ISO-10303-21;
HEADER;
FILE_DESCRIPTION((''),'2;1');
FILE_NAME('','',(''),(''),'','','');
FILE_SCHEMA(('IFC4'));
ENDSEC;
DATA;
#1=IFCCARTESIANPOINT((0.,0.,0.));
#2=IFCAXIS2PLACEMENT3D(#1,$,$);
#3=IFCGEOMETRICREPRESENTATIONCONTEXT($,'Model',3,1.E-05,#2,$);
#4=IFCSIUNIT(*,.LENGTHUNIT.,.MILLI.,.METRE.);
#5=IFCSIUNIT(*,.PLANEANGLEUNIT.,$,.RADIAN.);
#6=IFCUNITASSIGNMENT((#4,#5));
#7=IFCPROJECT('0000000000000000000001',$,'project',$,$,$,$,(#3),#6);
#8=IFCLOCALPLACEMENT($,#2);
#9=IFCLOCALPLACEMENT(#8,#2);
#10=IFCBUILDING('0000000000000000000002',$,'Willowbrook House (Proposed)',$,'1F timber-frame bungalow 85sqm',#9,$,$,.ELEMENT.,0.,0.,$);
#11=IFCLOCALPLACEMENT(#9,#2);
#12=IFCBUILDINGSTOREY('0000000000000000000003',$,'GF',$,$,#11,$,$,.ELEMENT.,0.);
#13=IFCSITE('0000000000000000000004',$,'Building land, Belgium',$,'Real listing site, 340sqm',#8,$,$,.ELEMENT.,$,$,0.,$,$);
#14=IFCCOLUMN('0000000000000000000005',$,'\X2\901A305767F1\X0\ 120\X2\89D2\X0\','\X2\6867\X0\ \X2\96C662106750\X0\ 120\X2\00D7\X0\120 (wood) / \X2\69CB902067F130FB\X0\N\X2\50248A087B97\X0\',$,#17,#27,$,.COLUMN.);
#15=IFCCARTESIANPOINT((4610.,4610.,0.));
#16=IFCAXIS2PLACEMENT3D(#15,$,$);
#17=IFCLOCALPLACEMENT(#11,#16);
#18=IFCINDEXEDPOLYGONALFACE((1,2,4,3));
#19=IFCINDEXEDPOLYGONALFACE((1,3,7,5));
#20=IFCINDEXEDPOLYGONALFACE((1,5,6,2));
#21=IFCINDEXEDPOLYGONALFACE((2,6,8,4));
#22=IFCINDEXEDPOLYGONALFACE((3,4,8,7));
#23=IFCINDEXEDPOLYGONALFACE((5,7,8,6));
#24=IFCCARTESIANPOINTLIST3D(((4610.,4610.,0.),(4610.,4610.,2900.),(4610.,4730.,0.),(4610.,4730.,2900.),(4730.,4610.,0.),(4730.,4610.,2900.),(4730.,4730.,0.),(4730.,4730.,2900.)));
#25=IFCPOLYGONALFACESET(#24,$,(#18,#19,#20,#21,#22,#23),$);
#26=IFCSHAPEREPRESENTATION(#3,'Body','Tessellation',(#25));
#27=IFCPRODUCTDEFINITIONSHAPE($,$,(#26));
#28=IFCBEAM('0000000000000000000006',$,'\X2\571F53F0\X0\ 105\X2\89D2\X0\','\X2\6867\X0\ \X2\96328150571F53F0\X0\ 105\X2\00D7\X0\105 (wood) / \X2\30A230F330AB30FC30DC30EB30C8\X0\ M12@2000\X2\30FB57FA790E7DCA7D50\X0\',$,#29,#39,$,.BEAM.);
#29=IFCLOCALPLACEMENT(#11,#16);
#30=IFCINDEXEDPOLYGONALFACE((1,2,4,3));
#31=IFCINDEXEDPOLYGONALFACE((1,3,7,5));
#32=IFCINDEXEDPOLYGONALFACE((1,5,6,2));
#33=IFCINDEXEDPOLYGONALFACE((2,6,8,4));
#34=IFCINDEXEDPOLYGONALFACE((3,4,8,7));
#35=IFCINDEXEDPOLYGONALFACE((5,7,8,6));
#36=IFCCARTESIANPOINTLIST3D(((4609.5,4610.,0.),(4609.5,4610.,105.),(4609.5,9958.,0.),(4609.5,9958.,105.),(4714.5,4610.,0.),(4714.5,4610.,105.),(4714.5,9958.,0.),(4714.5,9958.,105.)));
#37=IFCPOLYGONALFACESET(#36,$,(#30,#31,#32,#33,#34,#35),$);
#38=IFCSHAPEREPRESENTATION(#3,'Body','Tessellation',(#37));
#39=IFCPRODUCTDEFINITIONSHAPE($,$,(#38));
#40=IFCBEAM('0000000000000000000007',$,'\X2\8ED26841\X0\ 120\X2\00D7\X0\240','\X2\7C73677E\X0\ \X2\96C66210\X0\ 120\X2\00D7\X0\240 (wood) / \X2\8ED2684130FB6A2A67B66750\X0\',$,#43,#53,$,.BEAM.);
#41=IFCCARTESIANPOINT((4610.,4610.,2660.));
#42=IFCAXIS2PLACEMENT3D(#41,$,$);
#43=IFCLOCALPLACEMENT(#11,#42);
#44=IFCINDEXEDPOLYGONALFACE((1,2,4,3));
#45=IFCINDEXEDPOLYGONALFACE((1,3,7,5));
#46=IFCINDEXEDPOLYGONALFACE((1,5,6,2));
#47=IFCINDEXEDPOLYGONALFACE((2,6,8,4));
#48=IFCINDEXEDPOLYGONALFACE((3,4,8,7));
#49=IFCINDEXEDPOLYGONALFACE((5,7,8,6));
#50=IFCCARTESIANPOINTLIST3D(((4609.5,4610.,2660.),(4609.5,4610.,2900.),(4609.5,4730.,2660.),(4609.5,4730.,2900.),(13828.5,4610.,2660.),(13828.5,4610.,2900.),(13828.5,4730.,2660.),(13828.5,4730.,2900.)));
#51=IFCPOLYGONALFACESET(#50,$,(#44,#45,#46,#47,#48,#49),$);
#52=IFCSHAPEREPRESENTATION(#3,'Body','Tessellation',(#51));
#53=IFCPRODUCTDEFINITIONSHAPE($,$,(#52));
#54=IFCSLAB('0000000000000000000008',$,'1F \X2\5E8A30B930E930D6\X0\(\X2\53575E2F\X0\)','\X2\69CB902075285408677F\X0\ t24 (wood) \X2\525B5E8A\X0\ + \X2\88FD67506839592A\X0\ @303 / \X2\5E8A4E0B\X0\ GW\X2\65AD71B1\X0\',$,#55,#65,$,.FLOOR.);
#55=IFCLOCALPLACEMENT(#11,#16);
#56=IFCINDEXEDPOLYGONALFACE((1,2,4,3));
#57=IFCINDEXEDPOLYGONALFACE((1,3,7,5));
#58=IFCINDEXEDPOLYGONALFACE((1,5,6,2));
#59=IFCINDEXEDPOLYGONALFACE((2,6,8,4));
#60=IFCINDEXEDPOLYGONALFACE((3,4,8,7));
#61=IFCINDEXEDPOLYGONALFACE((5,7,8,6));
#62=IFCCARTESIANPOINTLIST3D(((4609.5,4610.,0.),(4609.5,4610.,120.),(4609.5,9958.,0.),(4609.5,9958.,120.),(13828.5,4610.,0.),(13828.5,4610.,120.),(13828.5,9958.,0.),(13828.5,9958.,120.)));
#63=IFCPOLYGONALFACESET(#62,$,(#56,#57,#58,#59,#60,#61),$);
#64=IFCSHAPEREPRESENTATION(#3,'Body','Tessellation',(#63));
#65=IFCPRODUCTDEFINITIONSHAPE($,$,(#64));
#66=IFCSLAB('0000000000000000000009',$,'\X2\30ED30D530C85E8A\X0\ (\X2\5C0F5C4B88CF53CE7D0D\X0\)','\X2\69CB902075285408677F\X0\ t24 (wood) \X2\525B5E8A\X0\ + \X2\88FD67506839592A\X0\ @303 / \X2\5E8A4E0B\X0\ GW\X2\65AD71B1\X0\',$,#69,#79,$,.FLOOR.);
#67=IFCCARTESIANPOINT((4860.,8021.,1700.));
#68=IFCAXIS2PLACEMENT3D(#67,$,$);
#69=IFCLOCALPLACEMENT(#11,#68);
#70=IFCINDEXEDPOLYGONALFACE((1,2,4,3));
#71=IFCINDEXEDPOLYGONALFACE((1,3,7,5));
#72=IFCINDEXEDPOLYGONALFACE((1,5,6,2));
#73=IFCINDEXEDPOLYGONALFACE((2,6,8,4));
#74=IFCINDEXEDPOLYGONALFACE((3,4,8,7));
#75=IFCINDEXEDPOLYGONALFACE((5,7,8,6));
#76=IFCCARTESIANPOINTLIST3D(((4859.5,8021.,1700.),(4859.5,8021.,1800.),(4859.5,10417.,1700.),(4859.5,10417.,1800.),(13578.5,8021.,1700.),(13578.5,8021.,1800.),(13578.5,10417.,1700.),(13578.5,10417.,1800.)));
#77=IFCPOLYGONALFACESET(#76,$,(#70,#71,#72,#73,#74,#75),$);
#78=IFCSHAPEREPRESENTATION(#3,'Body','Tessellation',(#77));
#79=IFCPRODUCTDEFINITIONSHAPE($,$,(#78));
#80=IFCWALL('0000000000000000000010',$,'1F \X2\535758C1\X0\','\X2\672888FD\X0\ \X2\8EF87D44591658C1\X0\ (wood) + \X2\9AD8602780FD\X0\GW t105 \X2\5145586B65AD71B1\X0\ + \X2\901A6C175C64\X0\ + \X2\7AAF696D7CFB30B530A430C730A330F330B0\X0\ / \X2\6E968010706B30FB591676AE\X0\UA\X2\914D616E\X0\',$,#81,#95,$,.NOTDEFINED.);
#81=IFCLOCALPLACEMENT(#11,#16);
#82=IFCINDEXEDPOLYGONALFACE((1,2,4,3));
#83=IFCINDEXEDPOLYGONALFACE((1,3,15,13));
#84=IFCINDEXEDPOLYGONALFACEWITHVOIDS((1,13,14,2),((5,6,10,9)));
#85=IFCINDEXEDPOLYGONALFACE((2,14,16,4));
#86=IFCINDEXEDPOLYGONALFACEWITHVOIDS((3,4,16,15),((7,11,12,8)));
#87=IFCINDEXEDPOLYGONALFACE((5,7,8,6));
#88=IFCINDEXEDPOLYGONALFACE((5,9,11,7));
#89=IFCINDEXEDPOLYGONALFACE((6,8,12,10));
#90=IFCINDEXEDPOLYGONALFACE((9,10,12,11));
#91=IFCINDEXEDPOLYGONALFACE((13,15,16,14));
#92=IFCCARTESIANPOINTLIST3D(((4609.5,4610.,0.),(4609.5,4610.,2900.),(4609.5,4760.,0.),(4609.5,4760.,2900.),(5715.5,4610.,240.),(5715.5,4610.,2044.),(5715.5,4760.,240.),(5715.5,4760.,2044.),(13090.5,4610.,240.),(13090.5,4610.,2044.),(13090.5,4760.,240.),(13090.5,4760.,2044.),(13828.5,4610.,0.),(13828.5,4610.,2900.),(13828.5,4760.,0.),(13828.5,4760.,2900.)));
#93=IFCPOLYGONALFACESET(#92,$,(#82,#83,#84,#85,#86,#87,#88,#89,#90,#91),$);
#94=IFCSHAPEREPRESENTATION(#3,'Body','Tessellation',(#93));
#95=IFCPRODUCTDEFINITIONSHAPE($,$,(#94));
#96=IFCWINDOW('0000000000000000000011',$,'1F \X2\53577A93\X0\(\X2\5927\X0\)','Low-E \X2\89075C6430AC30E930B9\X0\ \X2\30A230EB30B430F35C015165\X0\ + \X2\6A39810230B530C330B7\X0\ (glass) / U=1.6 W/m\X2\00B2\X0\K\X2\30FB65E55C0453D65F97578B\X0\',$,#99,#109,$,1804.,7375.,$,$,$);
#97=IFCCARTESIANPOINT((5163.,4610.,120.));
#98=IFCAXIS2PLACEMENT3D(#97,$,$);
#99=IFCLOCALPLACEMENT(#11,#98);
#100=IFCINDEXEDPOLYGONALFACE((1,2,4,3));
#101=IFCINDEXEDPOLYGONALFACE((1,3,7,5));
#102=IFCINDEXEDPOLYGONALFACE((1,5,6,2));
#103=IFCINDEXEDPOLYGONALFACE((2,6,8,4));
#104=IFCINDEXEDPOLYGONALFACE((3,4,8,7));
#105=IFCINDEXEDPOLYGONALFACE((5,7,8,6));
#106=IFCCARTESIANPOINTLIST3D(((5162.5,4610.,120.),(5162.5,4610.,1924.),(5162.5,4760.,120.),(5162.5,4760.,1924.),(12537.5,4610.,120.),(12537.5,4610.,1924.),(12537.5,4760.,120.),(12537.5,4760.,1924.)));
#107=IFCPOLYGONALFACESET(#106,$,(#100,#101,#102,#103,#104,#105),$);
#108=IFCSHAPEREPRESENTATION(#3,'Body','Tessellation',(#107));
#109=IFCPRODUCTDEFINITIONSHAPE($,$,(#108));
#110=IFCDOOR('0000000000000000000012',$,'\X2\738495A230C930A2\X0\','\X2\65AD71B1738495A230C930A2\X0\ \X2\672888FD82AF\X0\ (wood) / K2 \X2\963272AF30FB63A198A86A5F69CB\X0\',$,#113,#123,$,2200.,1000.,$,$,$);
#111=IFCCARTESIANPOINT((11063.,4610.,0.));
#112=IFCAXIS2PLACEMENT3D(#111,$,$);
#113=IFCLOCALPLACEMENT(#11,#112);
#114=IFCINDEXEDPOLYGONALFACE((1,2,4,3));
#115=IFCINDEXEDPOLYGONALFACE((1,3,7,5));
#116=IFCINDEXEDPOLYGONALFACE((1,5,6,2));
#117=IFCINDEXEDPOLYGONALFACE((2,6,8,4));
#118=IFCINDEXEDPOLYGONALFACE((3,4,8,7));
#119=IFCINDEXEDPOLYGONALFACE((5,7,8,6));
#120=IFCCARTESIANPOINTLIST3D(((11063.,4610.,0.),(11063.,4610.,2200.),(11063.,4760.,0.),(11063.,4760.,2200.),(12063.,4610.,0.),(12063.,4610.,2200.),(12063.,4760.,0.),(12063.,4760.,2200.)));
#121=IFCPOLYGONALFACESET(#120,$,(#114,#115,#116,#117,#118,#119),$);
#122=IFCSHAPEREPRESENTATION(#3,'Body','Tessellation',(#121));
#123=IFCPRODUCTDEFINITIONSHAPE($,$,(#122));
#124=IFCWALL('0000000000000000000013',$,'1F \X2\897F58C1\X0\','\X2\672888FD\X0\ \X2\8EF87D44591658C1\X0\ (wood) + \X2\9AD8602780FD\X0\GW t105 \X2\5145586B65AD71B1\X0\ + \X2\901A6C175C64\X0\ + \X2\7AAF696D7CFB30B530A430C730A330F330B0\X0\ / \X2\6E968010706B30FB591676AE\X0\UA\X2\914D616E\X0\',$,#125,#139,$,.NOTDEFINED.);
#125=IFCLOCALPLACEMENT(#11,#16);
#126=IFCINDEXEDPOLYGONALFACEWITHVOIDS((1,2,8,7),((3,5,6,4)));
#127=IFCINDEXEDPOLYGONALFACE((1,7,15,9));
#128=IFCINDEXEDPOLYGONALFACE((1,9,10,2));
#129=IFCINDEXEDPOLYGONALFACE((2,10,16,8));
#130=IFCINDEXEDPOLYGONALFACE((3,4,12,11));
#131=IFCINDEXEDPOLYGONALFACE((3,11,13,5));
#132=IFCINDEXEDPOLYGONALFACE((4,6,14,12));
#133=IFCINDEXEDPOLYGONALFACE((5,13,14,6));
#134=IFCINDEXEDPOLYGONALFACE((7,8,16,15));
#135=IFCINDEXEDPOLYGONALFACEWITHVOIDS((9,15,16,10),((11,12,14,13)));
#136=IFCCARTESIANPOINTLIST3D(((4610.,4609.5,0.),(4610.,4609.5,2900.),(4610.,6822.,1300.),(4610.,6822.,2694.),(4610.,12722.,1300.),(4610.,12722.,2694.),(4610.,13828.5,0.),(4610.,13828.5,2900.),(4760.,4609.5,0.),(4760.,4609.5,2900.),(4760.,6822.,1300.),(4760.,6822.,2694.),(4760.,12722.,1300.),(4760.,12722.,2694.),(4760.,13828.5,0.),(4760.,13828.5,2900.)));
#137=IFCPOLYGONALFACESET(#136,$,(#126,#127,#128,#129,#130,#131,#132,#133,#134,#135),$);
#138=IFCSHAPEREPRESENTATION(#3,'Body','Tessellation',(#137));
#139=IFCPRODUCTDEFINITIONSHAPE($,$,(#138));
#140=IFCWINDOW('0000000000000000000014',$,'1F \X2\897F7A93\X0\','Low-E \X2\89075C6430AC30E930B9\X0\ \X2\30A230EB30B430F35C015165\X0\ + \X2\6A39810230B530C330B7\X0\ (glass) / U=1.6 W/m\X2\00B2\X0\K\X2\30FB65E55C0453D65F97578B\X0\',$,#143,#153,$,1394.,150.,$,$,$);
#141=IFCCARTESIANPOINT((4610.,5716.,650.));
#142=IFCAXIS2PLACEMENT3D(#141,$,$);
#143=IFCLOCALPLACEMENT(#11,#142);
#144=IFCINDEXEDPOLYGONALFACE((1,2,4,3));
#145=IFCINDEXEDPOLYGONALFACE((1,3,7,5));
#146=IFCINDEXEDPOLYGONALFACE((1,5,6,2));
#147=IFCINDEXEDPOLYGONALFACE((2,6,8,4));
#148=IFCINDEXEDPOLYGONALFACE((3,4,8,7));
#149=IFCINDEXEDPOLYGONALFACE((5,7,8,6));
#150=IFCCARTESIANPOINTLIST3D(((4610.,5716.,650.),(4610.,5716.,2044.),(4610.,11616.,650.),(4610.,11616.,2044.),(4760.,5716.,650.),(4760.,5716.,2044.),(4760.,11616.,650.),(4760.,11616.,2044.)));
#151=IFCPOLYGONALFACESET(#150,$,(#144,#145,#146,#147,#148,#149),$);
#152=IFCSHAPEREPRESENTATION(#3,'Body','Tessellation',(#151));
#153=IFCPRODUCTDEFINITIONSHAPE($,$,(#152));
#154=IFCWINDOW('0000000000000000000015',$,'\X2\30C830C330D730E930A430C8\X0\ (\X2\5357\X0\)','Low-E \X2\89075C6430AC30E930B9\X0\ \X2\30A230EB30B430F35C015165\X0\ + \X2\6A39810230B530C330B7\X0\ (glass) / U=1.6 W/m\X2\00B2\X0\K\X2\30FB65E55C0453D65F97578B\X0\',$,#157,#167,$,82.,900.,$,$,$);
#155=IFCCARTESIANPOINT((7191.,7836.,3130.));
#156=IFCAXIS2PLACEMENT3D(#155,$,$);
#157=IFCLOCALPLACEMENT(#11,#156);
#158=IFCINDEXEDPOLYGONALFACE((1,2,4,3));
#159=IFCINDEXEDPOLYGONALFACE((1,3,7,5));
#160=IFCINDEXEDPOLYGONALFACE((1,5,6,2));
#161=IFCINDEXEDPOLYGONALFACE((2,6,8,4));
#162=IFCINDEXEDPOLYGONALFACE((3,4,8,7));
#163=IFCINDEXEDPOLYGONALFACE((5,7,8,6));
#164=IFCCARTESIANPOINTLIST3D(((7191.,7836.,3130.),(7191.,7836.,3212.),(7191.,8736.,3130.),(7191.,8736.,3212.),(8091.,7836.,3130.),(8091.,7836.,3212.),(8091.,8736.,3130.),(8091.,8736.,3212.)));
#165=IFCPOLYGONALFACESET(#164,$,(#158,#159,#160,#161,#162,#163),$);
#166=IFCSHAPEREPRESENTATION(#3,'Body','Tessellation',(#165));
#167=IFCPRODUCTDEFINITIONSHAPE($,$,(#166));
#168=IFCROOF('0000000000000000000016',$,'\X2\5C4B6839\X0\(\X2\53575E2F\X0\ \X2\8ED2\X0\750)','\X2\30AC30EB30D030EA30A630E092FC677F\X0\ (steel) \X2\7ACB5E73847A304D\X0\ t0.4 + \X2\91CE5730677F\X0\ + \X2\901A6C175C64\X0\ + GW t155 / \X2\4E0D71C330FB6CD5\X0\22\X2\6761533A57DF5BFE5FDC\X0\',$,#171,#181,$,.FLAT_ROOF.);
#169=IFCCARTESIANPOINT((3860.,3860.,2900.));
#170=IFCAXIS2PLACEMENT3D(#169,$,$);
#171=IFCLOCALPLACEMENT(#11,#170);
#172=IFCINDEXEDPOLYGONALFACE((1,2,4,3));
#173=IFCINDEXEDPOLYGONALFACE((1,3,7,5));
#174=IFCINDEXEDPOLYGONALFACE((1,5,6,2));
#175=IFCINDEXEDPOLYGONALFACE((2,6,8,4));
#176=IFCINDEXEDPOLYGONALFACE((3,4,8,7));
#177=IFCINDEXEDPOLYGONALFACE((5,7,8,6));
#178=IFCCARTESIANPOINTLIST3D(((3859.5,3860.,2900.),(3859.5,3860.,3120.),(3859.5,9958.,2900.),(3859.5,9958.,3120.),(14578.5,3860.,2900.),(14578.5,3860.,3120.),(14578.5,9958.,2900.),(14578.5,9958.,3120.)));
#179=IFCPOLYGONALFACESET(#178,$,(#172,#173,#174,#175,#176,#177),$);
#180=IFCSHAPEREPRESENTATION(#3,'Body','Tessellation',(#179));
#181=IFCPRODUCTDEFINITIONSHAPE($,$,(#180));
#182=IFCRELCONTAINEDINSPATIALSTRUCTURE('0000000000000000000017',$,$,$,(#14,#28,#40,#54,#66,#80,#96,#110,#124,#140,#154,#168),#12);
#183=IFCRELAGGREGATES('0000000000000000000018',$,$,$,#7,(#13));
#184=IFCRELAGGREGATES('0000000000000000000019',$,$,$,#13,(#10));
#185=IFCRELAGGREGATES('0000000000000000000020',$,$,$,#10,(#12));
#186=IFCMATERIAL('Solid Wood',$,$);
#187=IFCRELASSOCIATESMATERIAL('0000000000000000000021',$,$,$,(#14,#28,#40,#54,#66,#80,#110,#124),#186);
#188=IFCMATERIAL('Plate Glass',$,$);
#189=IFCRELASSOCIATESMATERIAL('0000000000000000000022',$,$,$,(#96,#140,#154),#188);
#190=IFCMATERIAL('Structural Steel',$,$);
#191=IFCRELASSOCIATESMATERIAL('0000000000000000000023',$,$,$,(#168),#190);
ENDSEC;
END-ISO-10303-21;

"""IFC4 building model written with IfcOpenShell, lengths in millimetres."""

from ifc_helpers import new_model, si_unit, frame, frame_2d, origin, place, context, project, spatial, rectangle, extrude, material, element, fill, save


model = new_model("IFC4")

# Units and contexts
model_context = context("Model", 3, precision=1e-05, world=origin())
ifc_project = project(units=[si_unit("LENGTHUNIT", "METRE", prefix="MILLI"), si_unit("PLANEANGLEUNIT", "RADIAN")], contexts=[model_context])

# Site, building, storey
site_placement = place(None, origin())
site = spatial("IfcSite", under=ifc_project, at=site_placement, Name="Building land, Belgium", ObjectType="Real listing site, 340sqm", CompositionType="ELEMENT", RefElevation=0.0)
building_placement = place(site_placement, origin())
building = spatial("IfcBuilding", under=site, at=building_placement, Name="Willowbrook House (Proposed)", ObjectType="1F timber-frame bungalow 85sqm", CompositionType="ELEMENT", ElevationOfRefHeight=0.0, ElevationOfTerrain=0.0)
storey_placement = place(building_placement, origin())
storey = spatial("IfcBuildingStorey", under=building, at=storey_placement, Name="GF", CompositionType="ELEMENT", Elevation=0.0)

# Column
ifc_material_1 = material(Name="Solid Wood")
column_1_placement = place(storey_placement, frame((4610.0, 4610.0, 0.0)))
element("IfcColumn", 1, at=column_1_placement, inside=storey, material=ifc_material_1, Name="通し柱 120角", Description="桧 集成材 120×120 (wood) / 構造柱・N値計算", PredefinedType="COLUMN", context=model_context, shape_type="SweptSolid", body=[
    extrude(rectangle(XDim=120.0, YDim=120.0, at=frame_2d((60.0, 60.0))), frame((4610.0, 4610.0, 0.0)), (0.0, 0.0, 1.0), 2900.0),
])

# Beams
beam_1_placement = place(storey_placement, frame((4610.0, 4610.0, 0.0)))
element("IfcBeam", 2, at=beam_1_placement, inside=storey, material=ifc_material_1, Name="土台 105角", Description="桧 防腐土台 105×105 (wood) / アンカーボルト M12@2000・基礎緊結", PredefinedType="BEAM", context=model_context, shape_type="SweptSolid", body=[
    extrude(rectangle(XDim=105.0, YDim=5348.0, at=frame_2d((52.0, 2674.0))), frame((4610.0, 4610.0, 0.0)), (0.0, 0.0, 1.0), 105.0),
])
beam_2_placement = place(storey_placement, frame((4610.0, 4610.0, 2660.0)))
element("IfcBeam", 3, at=beam_2_placement, inside=storey, material=ifc_material_1, Name="軒桁 120×240", Description="米松 集成 120×240 (wood) / 軒桁・横架材", PredefinedType="BEAM", context=model_context, shape_type="SweptSolid", body=[
    extrude(rectangle(XDim=9219.0, YDim=120.0, at=frame_2d((4609.0, 60.0))), frame((4610.0, 4610.0, 2660.0)), (0.0, 0.0, 1.0), 240.0),
])

# Slabs
slab_1_placement = place(storey_placement, frame((4610.0, 4610.0, 0.0)))
element("IfcSlab", 4, at=slab_1_placement, inside=storey, material=ifc_material_1, Name="1F 床スラブ(南帯)", Description="構造用合板 t24 (wood) 剛床 + 製材根太 @303 / 床下 GW断熱", PredefinedType="FLOOR", context=model_context, shape_type="SweptSolid", body=[
    extrude(rectangle(XDim=9219.0, YDim=5348.0, at=frame_2d((4609.0, 2674.0))), frame((4610.0, 4610.0, 0.0)), (0.0, 0.0, 1.0), 120.0),
])
slab_2_placement = place(storey_placement, frame((4860.0, 8021.0, 1700.0)))
element("IfcSlab", 5, at=slab_2_placement, inside=storey, material=ifc_material_1, Name="ロフト床 (小屋裏収納)", Description="構造用合板 t24 (wood) 剛床 + 製材根太 @303 / 床下 GW断熱", PredefinedType="FLOOR", context=model_context, shape_type="SweptSolid", body=[
    extrude(rectangle(XDim=8719.0, YDim=2396.0, at=frame_2d((4359.0, 1198.0))), frame((4860.0, 8021.0, 1700.0)), (0.0, 0.0, 1.0), 100.0),
])

# Wall, openings, window, door
wall_1_placement = place(storey_placement, frame((4610.0, 4610.0, 0.0)))
wall_1 = element("IfcWall", 6, at=wall_1_placement, inside=storey, material=ifc_material_1, Name="1F 南壁", Description="木製 軸組外壁 (wood) + 高性能GW t105 充填断熱 + 通気層 + 窯業系サイディング / 準耐火・外皮UA配慮", PredefinedType="NOTDEFINED", context=model_context, shape_type="SweptSolid", body=[
    extrude(rectangle(XDim=9219.0, YDim=150.0, at=frame_2d((4609.0, 75.0))), frame((4610.0, 4610.0, 0.0)), (0.0, 0.0, 1.0), 2900.0),
])
opening_1_placement = place(storey_placement, frame((5163.0, 4610.0, 120.0)))
opening_1 = element("IfcOpeningElement", 7, at=opening_1_placement, cuts=wall_1, PredefinedType="NOTDEFINED", context=model_context, shape_type="SweptSolid", body=[
    extrude(rectangle(XDim=7375.0, YDim=150.0, at=frame_2d((3687.0, 75.0))), frame((5163.0, 4610.0, 120.0)), (0.0, 0.0, 1.0), 1804.0),
])
opening_2_placement = place(storey_placement, frame((11063.0, 4610.0, 0.0)))
opening_2 = element("IfcOpeningElement", 8, at=opening_2_placement, cuts=wall_1, PredefinedType="NOTDEFINED", context=model_context, shape_type="SweptSolid", body=[
    extrude(rectangle(XDim=1000.0, YDim=150.0, at=frame_2d((500.0, 75.0))), frame((11063.0, 4610.0, 0.0)), (0.0, 0.0, 1.0), 2200.0),
])
ifc_material_2 = material(Name="Plate Glass")
window_1_placement = place(storey_placement, frame((5163.0, 4610.0, 120.0)))
window_1 = element("IfcWindow", 9, at=window_1_placement, inside=storey, material=ifc_material_2, Name="1F 南窓(大)", Description="Low-E 複層ガラス アルゴン封入 + 樹脂サッシ (glass) / U=1.6 W/m²K・日射取得型", OverallHeight=1804.0, OverallWidth=7375.0, context=model_context, shape_type="SweptSolid", body=[
    extrude(rectangle(XDim=7375.0, YDim=150.0, at=frame_2d((3687.0, 75.0))), frame((5163.0, 4610.0, 120.0)), (0.0, 0.0, 1.0), 1804.0),
])
fill(opening_1, window_1)
door_1_placement = place(storey_placement, frame((11063.0, 4610.0, 0.0)))
door_1 = element("IfcDoor", 10, at=door_1_placement, inside=storey, material=ifc_material_1, Name="玄関ドア", Description="断熱玄関ドア 木製芯 (wood) / K2 防犯・採風機構", OverallHeight=2200.0, OverallWidth=1000.0, context=model_context, shape_type="SweptSolid", body=[
    extrude(rectangle(XDim=1000.0, YDim=150.0, at=frame_2d((500.0, 75.0))), frame((11063.0, 4610.0, 0.0)), (0.0, 0.0, 1.0), 2200.0),
])
fill(opening_2, door_1)

# Wall, opening, window
wall_2_placement = place(storey_placement, frame((4610.0, 4610.0, 0.0)))
wall_2 = element("IfcWall", 11, at=wall_2_placement, inside=storey, material=ifc_material_1, Name="1F 西壁", Description="木製 軸組外壁 (wood) + 高性能GW t105 充填断熱 + 通気層 + 窯業系サイディング / 準耐火・外皮UA配慮", PredefinedType="NOTDEFINED", context=model_context, shape_type="SweptSolid", body=[
    extrude(rectangle(XDim=150.0, YDim=9219.0, at=frame_2d((75.0, 4609.0))), frame((4610.0, 4610.0, 0.0)), (0.0, 0.0, 1.0), 2900.0),
])
opening_3_placement = place(storey_placement, frame((4610.0, 5716.0, 650.0)))
opening_3 = element("IfcOpeningElement", 12, at=opening_3_placement, cuts=wall_2, PredefinedType="NOTDEFINED", context=model_context, shape_type="SweptSolid", body=[
    extrude(rectangle(XDim=150.0, YDim=5900.0, at=frame_2d((75.0, 2950.0))), frame((4610.0, 5716.0, 650.0)), (0.0, 0.0, 1.0), 1394.0),
])
window_2_placement = place(storey_placement, frame((4610.0, 5716.0, 650.0)))
window_2 = element("IfcWindow", 13, at=window_2_placement, inside=storey, material=ifc_material_2, Name="1F 西窓", Description="Low-E 複層ガラス アルゴン封入 + 樹脂サッシ (glass) / U=1.6 W/m²K・日射取得型", OverallHeight=1394.0, OverallWidth=150.0, context=model_context, shape_type="SweptSolid", body=[
    extrude(rectangle(XDim=150.0, YDim=5900.0, at=frame_2d((75.0, 2950.0))), frame((4610.0, 5716.0, 650.0)), (0.0, 0.0, 1.0), 1394.0),
])
fill(opening_3, window_2)

# Window
window_3_placement = place(storey_placement, frame((7191.0, 7836.0, 3130.0)))
element("IfcWindow", 14, at=window_3_placement, inside=storey, material=ifc_material_2, Name="トップライト (南)", Description="Low-E 複層ガラス アルゴン封入 + 樹脂サッシ (glass) / U=1.6 W/m²K・日射取得型", OverallHeight=82.0, OverallWidth=900.0, context=model_context, shape_type="SweptSolid", body=[
    extrude(rectangle(XDim=900.0, YDim=900.0, at=frame_2d((450.0, 450.0))), frame((7191.0, 7836.0, 3130.0)), (0.0, 0.0, 1.0), 82.0),
])

# Roof
ifc_material_3 = material(Name="Structural Steel")
roof_placement = place(storey_placement, frame((3860.0, 3860.0, 2900.0)))
element("IfcRoof", 15, at=roof_placement, inside=storey, material=ifc_material_3, Name="屋根(南帯 軒750)", Description="ガルバリウム鋼板 (steel) 立平葺き t0.4 + 野地板 + 通気層 + GW t155 / 不燃・法22条区域対応", PredefinedType="FLAT_ROOF", context=model_context, shape_type="SweptSolid", body=[
    extrude(rectangle(XDim=10719.0, YDim=6098.0, at=frame_2d((5359.0, 3049.0))), frame((3860.0, 3860.0, 2900.0)), (0.0, 0.0, 1.0), 220.0),
])

save(model, "model.ifc")
